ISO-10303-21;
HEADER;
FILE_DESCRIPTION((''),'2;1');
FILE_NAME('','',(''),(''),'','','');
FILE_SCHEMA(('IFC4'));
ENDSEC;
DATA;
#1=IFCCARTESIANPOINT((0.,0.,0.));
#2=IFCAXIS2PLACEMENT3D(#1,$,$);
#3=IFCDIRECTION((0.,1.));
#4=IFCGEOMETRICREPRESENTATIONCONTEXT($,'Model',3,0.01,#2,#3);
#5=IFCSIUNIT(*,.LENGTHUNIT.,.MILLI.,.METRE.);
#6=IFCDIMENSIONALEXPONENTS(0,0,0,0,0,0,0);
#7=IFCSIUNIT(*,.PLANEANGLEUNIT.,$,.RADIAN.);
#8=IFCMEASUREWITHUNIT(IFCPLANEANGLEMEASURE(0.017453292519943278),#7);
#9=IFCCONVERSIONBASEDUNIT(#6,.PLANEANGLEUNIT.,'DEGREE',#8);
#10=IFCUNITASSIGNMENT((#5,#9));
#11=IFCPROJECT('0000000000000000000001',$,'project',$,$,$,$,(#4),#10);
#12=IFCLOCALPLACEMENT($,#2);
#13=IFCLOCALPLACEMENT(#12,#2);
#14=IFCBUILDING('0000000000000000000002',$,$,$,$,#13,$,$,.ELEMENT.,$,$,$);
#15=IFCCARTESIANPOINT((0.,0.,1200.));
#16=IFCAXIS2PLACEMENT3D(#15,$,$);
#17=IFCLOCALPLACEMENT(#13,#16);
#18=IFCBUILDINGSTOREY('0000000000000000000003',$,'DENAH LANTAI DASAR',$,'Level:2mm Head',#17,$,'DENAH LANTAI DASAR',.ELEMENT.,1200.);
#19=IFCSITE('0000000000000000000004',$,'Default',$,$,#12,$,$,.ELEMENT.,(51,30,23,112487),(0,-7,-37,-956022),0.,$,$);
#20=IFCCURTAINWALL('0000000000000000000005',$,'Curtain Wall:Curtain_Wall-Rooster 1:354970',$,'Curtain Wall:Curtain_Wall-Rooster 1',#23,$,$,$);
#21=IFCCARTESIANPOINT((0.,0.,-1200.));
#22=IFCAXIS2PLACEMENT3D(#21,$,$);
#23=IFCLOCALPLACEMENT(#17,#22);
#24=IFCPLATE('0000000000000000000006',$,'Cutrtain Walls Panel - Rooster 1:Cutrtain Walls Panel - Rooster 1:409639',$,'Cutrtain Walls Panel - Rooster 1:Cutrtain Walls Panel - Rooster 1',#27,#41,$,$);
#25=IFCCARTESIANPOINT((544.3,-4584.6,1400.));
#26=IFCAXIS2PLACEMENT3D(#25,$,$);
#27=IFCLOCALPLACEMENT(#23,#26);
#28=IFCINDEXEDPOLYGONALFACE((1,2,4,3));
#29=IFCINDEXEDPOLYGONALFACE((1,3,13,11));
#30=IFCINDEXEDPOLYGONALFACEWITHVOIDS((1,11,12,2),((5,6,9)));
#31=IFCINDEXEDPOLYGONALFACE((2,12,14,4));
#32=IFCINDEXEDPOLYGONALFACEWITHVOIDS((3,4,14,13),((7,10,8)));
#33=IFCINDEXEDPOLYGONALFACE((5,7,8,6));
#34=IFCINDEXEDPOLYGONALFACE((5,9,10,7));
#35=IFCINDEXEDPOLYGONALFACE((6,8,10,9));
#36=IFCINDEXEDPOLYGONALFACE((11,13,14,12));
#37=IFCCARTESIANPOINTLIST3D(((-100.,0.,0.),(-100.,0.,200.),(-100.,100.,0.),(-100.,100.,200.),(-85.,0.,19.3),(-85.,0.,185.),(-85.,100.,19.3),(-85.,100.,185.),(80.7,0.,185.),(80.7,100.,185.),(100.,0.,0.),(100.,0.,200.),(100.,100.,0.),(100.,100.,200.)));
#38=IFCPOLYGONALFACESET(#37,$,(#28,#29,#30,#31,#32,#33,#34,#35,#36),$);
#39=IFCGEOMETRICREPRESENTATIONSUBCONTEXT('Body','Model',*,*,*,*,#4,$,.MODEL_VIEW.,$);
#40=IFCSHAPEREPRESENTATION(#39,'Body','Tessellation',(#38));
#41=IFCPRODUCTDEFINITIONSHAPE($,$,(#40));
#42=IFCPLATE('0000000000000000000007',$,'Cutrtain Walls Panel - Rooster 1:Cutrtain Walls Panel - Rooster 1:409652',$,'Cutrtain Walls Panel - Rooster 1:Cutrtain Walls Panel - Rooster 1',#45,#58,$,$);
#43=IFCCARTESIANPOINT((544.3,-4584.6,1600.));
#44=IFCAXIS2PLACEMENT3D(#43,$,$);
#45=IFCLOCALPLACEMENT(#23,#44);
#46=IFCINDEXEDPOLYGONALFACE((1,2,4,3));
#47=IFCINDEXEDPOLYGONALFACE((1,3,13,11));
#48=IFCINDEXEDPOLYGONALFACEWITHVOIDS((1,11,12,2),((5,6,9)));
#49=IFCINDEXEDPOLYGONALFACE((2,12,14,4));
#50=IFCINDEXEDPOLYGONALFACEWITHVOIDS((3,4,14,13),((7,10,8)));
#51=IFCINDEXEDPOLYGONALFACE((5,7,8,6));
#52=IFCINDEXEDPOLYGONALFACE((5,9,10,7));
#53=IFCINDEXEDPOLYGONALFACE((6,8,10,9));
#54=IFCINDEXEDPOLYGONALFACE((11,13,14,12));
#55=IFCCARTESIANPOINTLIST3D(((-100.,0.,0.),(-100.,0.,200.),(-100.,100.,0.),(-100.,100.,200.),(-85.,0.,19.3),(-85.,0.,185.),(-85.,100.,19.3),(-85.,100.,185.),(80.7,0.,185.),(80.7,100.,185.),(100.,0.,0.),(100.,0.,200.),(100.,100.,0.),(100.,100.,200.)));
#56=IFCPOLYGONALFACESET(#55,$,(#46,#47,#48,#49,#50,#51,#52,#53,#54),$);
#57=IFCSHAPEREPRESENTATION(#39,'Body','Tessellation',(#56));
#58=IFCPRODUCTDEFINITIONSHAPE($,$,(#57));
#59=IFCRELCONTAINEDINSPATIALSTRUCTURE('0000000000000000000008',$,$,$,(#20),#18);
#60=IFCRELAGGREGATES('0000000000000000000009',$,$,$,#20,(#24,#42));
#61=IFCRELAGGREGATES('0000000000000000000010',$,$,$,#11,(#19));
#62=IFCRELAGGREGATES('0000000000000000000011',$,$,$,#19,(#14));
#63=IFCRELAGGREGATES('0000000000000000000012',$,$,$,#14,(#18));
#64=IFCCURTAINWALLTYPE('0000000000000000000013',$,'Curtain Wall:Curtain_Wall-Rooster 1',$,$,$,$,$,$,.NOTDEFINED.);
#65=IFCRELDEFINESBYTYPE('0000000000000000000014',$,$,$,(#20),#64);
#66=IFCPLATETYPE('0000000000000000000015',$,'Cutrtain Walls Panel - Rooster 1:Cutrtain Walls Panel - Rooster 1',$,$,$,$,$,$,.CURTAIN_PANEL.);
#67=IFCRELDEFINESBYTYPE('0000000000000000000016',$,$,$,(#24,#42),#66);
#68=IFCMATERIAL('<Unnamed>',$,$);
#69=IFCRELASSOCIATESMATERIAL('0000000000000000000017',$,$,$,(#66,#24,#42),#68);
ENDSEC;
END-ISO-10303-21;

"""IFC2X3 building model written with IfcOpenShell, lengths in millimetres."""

from ifc_helpers import new_model, entity, si_unit, converted_unit, direction, frame, origin, place, context, subcontext, project, spatial, polyline, outline, extrude, source, transform, mapped, material, type_object, type_shapes, element, aggregate, save


model = new_model("IFC2X3")

# Units and contexts
model_context = context("Model", 3, precision=0.01, world=origin(), true_north=direction((0.0, 1.0)))
body_context = subcontext(model_context, "Body", "Model", "MODEL_VIEW")
ifc_project = project(units=[si_unit("LENGTHUNIT", "METRE", prefix="MILLI"), converted_unit("PLANEANGLEUNIT", "DEGREE", entity("IfcPlaneAngleMeasure", 0.017453292519943278), si_unit("PLANEANGLEUNIT", "RADIAN"), dimensions=[0, 0, 0, 0, 0, 0, 0])], contexts=[model_context])

# Site, building, storey
site_placement = place(None, origin())
site = spatial("IfcSite", under=ifc_project, at=site_placement, Name="Default", CompositionType="ELEMENT", RefLatitude=(51, 30, 23, 112487), RefLongitude=(0, -7, -37, -956022), RefElevation=0.0)
building_placement = place(site_placement, origin())
building = spatial("IfcBuilding", under=site, at=building_placement, CompositionType="ELEMENT")
storey_placement = place(building_placement, frame((0.0, 0.0, 1200.0)))
storey = spatial("IfcBuildingStorey", under=building, at=storey_placement, Name="DENAH LANTAI DASAR", ObjectType="Level:2mm Head", LongName="DENAH LANTAI DASAR", CompositionType="ELEMENT", Elevation=1200.0)

# Curtain wall
curtain_wall_type = type_object("IfcCurtainWallType", Name="Curtain Wall:Curtain_Wall-Rooster 1", PredefinedType="NOTDEFINED")
curtain_wall_1_placement = place(storey_placement, frame((0.0, 0.0, -1200.0)))
curtain_wall_1 = element("IfcCurtainWall", 1, at=curtain_wall_1_placement, inside=storey, type_object=curtain_wall_type, Name="Curtain Wall:Curtain_Wall-Rooster 1:354970", ObjectType="Curtain Wall:Curtain_Wall-Rooster 1")
ifc_material_1 = material(Name="<Unnamed>")

# Plates
plate_type_1 = type_object("IfcPlateType", Name="Cutrtain Walls Panel - Rooster 1:Cutrtain Walls Panel - Rooster 1", PredefinedType="CURTAIN_PANEL", material=ifc_material_1)
shared_shape_1 = source(origin(), body_context, "Body", "SweptSolid", [
    extrude(outline(polyline([(-100.0, -100.0), (100.0, -100.0), (100.0, 100.0), (-100.0, 100.0), (-100.0, -100.0)]), holes=[polyline([(80.7, 85.0), (-85.0, -80.7), (-85.0, 85.0), (80.7, 85.0)])]), frame((0.0, 0.0, 100.0), z_axis=(0.0, 1.0, 0.0), x_axis=(0.0, 0.0, -1.0)), (0.0, 0.0, 1.0), 100.0),
])
type_shapes(plate_type_1, [shared_shape_1])
plate_1_placement = place(curtain_wall_1_placement, frame((544.3, -4584.6, 1400.0)))
plate_1 = element("IfcPlate", 2, at=plate_1_placement, type_object=plate_type_1, material=ifc_material_1, Name="Cutrtain Walls Panel - Rooster 1:Cutrtain Walls Panel - Rooster 1:409639", ObjectType="Cutrtain Walls Panel - Rooster 1:Cutrtain Walls Panel - Rooster 1", context=body_context, shape_type="MappedRepresentation", body=[
    mapped(shared_shape_1, transform((0.0, 0.0, 0.0), scale=1.0)),
])
plate_2_placement = place(curtain_wall_1_placement, frame((544.3, -4584.6, 1600.0)))
plate_2 = element("IfcPlate", 3, at=plate_2_placement, type_object=plate_type_1, material=ifc_material_1, Name="Cutrtain Walls Panel - Rooster 1:Cutrtain Walls Panel - Rooster 1:409652", ObjectType="Cutrtain Walls Panel - Rooster 1:Cutrtain Walls Panel - Rooster 1", context=body_context, shape_type="MappedRepresentation", body=[
    mapped(shared_shape_1, transform((0.0, 0.0, 0.0), scale=1.0)),
])
aggregate(curtain_wall_1, [plate_1, plate_2])

save(model, "model.ifc")
